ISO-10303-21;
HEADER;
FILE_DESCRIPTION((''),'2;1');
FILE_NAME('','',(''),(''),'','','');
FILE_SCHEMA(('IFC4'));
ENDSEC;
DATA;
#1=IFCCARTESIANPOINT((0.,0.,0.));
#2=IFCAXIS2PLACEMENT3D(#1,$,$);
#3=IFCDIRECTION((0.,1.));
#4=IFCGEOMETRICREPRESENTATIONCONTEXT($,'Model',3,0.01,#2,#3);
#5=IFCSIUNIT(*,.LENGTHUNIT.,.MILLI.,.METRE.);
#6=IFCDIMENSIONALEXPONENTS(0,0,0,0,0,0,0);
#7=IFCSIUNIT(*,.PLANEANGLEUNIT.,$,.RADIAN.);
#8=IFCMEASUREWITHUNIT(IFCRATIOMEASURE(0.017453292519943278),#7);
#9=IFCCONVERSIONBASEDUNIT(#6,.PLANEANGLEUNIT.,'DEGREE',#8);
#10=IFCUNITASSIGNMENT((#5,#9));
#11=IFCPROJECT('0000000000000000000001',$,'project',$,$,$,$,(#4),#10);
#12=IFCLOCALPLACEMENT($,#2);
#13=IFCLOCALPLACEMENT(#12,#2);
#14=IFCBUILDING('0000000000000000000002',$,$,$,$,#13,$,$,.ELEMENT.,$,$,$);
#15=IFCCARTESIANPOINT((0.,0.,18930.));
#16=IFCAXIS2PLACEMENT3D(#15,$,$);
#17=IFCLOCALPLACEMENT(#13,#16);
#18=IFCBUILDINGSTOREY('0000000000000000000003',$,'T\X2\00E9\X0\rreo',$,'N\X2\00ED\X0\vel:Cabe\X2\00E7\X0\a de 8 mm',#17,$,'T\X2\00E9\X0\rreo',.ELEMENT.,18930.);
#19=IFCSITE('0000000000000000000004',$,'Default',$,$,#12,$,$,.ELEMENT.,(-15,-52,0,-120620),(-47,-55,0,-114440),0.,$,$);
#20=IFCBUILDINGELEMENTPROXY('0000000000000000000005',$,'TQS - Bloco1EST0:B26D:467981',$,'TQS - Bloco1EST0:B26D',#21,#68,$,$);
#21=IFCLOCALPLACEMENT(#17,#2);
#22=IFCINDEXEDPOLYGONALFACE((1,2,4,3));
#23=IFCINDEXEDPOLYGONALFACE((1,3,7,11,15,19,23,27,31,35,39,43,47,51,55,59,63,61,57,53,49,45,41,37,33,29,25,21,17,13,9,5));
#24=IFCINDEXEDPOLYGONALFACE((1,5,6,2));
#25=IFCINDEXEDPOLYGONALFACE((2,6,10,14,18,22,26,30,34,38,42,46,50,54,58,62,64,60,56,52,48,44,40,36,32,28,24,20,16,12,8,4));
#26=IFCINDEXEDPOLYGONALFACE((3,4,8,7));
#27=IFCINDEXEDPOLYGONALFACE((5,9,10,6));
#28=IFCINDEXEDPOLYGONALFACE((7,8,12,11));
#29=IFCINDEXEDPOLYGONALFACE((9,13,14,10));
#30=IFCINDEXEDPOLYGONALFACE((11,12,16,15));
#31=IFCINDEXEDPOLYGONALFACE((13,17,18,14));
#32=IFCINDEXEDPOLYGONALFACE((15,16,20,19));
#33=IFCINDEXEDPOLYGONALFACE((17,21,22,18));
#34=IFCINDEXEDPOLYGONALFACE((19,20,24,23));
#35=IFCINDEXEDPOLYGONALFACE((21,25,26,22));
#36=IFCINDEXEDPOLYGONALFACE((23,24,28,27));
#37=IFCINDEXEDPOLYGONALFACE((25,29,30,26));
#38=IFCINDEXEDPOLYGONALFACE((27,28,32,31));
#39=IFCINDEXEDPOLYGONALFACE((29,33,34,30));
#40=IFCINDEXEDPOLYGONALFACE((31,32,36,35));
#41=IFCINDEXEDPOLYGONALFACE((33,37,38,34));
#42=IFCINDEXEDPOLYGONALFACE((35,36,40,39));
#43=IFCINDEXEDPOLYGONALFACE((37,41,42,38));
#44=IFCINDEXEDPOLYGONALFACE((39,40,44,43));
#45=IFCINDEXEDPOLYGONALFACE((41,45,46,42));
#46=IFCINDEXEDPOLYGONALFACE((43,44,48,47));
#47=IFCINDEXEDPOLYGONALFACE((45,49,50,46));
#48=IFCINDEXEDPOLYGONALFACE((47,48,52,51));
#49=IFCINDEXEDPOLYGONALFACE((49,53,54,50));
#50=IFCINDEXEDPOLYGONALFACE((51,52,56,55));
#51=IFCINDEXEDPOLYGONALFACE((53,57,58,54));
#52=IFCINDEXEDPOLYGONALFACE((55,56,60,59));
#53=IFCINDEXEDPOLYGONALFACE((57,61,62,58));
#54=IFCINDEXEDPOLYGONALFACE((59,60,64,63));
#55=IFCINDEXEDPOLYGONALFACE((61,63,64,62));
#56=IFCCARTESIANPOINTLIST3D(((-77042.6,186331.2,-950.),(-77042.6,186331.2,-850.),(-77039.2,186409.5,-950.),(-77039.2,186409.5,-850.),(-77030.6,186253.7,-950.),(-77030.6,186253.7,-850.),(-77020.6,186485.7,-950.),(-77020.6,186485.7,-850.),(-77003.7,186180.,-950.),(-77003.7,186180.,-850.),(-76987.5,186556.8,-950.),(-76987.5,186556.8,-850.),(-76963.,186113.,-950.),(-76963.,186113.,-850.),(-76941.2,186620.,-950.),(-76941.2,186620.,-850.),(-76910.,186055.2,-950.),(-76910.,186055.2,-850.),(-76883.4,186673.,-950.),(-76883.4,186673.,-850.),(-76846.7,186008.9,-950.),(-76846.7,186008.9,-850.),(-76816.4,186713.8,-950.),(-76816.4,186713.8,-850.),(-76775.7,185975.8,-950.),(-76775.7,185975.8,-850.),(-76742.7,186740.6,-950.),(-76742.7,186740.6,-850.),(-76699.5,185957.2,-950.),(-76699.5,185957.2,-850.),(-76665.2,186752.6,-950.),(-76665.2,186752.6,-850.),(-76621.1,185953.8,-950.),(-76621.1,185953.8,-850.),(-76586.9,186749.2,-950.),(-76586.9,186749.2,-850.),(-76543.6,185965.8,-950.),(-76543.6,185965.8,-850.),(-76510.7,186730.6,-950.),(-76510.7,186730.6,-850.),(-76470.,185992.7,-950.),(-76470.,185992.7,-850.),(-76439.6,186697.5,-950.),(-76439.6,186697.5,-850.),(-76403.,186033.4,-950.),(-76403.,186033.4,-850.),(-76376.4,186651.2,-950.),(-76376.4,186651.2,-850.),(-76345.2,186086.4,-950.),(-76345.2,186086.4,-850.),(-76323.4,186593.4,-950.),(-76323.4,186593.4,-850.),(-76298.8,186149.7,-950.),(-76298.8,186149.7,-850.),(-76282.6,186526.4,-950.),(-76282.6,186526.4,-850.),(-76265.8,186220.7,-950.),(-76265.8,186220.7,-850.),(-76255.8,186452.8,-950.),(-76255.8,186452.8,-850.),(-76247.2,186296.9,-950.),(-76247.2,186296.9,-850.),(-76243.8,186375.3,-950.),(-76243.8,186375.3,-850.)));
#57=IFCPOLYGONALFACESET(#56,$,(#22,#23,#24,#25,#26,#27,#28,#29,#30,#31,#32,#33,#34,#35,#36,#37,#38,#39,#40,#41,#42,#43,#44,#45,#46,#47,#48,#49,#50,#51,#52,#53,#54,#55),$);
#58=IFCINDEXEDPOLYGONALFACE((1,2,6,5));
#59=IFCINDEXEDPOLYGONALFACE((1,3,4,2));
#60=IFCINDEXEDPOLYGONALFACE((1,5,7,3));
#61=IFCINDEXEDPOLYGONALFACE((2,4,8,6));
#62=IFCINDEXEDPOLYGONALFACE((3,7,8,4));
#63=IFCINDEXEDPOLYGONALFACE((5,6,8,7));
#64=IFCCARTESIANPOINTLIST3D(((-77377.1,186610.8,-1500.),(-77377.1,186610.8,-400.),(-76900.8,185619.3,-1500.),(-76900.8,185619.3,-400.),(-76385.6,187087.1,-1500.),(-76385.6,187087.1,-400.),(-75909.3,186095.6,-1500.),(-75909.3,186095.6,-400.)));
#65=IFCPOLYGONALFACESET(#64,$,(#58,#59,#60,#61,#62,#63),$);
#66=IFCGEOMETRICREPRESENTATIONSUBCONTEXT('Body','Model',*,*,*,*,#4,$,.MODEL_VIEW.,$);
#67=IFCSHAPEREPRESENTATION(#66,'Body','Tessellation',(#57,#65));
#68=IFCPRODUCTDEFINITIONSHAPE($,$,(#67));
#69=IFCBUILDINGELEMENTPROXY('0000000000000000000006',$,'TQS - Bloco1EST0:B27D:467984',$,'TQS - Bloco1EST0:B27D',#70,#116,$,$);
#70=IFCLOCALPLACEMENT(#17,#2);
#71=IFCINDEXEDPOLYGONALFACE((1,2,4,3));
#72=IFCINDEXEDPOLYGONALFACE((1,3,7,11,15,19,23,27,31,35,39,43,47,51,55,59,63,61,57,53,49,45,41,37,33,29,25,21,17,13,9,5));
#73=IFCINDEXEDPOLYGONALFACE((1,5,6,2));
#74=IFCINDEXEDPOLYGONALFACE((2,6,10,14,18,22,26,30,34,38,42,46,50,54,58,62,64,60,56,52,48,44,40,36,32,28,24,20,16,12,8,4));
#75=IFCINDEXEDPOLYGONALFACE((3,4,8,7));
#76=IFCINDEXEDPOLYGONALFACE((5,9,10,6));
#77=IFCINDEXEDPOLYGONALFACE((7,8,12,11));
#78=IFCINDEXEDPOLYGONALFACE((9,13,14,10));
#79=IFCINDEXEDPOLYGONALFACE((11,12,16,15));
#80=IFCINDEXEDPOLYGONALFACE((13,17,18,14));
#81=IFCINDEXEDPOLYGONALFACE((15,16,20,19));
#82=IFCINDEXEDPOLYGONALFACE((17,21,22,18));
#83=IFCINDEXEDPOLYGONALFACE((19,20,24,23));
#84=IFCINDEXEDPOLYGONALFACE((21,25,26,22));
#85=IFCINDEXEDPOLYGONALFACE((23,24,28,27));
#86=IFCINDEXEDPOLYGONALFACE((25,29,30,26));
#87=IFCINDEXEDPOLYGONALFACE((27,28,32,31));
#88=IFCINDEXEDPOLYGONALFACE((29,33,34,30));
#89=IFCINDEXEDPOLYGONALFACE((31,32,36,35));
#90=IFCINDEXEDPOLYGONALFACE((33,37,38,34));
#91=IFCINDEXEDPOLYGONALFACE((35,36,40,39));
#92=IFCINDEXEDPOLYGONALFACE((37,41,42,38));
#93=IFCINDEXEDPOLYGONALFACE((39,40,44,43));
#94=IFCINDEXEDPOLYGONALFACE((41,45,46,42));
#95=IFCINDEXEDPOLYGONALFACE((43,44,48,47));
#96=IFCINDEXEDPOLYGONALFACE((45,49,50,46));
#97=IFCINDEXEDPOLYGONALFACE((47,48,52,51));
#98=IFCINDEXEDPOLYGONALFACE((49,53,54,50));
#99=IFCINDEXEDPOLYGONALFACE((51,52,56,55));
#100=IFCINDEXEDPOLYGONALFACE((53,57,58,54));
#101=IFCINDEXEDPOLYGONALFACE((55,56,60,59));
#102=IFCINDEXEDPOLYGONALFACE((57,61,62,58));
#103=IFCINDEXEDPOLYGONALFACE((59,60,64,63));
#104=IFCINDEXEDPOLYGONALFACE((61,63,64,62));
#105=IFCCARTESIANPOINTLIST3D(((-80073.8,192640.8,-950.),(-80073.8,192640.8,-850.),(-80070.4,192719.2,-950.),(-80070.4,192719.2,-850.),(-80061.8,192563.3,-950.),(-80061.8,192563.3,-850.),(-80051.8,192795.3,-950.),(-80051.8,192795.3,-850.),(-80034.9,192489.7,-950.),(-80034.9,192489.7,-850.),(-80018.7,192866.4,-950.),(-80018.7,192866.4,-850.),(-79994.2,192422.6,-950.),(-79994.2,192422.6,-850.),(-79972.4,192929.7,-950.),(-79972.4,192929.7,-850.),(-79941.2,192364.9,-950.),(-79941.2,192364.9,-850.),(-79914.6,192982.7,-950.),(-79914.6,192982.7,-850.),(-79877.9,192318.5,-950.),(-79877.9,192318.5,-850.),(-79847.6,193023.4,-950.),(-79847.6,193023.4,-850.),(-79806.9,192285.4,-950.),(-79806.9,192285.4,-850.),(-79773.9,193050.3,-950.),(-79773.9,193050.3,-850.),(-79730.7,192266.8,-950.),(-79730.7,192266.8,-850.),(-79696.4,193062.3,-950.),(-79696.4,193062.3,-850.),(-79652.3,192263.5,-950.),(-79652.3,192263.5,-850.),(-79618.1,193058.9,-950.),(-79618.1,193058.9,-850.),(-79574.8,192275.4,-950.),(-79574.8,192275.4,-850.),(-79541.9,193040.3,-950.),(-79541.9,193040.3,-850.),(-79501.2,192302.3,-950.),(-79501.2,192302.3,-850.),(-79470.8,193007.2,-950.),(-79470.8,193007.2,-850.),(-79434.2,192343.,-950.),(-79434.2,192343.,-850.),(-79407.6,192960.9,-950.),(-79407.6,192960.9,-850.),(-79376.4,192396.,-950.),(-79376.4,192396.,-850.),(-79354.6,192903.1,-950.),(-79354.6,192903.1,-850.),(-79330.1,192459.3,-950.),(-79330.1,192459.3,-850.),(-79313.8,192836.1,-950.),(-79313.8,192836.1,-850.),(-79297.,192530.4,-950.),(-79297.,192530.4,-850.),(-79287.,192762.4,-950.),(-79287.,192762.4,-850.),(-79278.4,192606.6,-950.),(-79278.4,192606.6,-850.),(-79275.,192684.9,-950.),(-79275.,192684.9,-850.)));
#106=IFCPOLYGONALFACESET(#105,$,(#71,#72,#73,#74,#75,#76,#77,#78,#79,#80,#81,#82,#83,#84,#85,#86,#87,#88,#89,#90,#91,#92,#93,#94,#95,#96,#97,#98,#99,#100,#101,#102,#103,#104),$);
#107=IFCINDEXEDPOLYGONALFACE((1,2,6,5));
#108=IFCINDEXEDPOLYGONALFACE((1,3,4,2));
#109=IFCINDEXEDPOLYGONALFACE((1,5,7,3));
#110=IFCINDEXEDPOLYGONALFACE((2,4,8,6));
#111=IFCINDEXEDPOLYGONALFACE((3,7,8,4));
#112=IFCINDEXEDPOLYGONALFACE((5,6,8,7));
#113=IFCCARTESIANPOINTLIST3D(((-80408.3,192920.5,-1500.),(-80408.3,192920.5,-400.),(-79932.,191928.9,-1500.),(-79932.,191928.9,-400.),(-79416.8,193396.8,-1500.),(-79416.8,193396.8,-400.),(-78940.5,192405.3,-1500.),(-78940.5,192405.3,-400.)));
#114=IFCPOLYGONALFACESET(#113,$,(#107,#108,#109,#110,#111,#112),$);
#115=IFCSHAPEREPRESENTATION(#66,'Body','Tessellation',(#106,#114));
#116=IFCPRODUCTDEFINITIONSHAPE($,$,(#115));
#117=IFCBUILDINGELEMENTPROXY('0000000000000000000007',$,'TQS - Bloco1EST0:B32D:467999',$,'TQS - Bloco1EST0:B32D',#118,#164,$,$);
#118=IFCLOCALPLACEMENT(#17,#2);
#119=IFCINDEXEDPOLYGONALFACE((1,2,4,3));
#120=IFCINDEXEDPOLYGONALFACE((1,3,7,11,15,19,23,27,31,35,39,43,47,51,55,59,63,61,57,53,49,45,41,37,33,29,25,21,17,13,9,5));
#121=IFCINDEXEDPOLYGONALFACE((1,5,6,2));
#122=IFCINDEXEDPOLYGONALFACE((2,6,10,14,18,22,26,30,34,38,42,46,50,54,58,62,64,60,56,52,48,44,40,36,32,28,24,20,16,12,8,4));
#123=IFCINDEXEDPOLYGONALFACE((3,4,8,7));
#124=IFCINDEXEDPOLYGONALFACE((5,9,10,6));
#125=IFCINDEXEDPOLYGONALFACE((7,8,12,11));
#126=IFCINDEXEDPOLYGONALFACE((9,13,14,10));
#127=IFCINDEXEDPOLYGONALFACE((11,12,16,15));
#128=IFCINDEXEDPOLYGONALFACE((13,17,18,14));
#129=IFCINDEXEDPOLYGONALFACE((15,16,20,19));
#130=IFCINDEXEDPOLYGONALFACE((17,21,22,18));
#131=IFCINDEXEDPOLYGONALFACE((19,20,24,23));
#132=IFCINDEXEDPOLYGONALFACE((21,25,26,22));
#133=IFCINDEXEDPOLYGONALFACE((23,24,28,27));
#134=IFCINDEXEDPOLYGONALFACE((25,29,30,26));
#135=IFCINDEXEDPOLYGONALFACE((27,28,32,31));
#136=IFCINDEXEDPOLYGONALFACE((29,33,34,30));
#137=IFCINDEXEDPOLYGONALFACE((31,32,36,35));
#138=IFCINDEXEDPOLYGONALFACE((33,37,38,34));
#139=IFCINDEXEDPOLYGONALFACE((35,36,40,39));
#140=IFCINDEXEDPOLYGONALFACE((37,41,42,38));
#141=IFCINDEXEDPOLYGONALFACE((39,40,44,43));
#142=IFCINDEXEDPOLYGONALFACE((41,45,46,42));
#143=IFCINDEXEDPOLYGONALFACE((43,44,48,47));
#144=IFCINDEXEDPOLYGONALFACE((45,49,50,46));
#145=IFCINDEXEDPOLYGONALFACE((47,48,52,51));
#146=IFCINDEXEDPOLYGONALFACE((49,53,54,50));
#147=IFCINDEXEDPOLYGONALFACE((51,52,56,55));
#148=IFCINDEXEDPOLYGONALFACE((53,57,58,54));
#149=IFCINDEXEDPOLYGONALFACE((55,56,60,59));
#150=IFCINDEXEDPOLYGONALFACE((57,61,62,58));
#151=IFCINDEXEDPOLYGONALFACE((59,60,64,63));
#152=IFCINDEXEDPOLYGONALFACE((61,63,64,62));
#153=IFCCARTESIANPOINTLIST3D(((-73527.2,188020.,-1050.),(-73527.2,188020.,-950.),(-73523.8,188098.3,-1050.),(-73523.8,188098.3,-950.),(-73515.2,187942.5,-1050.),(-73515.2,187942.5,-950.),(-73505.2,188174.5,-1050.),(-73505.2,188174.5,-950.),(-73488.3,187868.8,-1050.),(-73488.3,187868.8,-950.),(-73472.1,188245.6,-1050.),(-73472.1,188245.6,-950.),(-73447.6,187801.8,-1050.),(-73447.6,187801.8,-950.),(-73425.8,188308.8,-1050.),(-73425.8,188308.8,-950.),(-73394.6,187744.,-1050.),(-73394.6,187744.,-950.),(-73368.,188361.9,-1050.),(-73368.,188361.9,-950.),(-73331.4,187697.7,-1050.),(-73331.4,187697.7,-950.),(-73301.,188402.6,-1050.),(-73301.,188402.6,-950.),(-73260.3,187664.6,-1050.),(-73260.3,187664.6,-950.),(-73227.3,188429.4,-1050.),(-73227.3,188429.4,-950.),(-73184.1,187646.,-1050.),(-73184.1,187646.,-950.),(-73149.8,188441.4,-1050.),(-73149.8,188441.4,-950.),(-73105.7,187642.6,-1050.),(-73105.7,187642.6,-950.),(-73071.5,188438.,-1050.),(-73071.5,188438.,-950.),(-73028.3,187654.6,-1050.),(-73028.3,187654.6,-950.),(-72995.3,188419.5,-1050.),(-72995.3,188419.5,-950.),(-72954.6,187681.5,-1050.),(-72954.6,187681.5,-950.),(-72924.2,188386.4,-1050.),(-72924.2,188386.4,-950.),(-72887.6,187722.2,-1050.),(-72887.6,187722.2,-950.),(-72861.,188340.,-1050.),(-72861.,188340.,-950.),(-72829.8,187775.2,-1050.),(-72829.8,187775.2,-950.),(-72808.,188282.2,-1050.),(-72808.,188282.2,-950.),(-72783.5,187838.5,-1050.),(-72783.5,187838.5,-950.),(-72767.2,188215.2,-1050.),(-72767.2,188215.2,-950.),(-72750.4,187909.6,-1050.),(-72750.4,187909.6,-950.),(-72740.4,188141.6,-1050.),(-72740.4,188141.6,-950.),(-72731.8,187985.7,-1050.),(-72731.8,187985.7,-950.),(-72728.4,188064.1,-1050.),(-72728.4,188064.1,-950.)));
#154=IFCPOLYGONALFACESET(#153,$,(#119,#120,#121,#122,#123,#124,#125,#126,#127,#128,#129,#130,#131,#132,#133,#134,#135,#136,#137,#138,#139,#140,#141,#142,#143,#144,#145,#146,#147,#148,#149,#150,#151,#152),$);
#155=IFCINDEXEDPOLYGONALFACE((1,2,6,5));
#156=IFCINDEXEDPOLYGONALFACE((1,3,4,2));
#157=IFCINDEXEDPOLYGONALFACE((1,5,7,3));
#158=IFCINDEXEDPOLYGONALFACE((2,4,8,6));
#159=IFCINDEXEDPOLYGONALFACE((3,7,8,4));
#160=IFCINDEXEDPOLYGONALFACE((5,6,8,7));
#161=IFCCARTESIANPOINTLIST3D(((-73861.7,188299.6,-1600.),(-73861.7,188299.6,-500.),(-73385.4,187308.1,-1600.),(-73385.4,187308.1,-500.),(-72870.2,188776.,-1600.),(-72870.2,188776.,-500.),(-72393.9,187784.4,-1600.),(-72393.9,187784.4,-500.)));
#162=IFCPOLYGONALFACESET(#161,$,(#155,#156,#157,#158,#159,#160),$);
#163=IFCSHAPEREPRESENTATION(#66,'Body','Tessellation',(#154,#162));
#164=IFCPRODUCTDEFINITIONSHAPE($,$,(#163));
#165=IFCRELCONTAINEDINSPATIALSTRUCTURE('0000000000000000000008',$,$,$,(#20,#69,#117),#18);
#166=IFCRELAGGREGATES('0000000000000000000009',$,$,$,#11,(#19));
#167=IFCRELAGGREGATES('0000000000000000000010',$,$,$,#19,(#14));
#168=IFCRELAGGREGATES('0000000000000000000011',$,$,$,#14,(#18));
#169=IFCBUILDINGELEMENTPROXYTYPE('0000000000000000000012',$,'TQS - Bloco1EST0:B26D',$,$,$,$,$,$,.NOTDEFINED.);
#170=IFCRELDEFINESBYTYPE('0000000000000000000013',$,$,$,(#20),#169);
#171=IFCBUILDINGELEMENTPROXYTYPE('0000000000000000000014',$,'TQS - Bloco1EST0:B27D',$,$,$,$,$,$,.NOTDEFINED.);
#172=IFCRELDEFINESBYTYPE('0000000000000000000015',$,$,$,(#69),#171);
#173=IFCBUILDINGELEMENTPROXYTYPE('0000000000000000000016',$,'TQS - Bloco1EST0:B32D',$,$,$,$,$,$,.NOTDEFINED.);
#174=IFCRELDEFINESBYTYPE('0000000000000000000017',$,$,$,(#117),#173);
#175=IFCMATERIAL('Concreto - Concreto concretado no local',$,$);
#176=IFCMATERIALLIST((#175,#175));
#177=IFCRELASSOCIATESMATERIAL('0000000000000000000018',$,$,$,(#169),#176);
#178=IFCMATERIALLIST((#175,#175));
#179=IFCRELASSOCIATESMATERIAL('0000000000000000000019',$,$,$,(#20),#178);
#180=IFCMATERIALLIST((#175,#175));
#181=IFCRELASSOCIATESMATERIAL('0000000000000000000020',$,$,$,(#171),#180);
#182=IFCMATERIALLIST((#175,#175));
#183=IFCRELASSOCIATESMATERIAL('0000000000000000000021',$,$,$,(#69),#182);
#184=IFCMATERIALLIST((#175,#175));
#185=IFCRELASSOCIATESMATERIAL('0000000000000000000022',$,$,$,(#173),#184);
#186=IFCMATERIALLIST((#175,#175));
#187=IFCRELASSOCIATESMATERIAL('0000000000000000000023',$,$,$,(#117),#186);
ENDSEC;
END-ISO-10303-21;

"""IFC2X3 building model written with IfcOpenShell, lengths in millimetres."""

from ifc_helpers import new_model, entity, si_unit, converted_unit, direction, frame, frame_2d, origin, origin_2d_with_axis, place, context, subcontext, project, spatial, rectangle, circle, extrude, source, transform, mapped, material, material_list, type_object, type_shapes, element, save


model = new_model("IFC2X3")

# Units and contexts
model_context = context("Model", 3, precision=0.01, world=origin(), true_north=direction((0.0, 1.0)))
body_context = subcontext(model_context, "Body", "Model", "MODEL_VIEW")
ifc_project = project(units=[si_unit("LENGTHUNIT", "METRE", prefix="MILLI"), converted_unit("PLANEANGLEUNIT", "DEGREE", entity("IfcRatioMeasure", 0.017453292519943278), si_unit("PLANEANGLEUNIT", "RADIAN"), dimensions=[0, 0, 0, 0, 0, 0, 0])], contexts=[model_context])

# Site, building, storey
site_placement = place(None, origin())
site = spatial("IfcSite", under=ifc_project, at=site_placement, Name="Default", CompositionType="ELEMENT", RefLatitude=(-15, -52, 0, -120620), RefLongitude=(-47, -55, 0, -114440), RefElevation=0.0)
building_placement = place(site_placement, origin())
building = spatial("IfcBuilding", under=site, at=building_placement, CompositionType="ELEMENT")
storey_placement = place(building_placement, frame((0.0, 0.0, 18930.0)))
storey = spatial("IfcBuildingStorey", under=building, at=storey_placement, Name="Térreo", ObjectType="Nível:Cabeça de 8 mm", LongName="Térreo", CompositionType="ELEMENT", Elevation=18930.0)

# Building element proxies
ifc_material_1 = material(Name="Concreto - Concreto concretado no local")
ifc_material_list_1 = material_list([ifc_material_1, ifc_material_1])
ifc_material_list_2 = material_list([ifc_material_1, ifc_material_1])
building_element_proxy_type_1 = type_object("IfcBuildingElementProxyType", Name="TQS - Bloco1EST0:B26D", PredefinedType="NOTDEFINED", material=ifc_material_list_2)
shared_shape_1 = source(origin(), body_context, "Body", "SweptSolid", [
    extrude(circle(Radius=400.0, at=frame_2d((0.0, 0.0), x_axis=(1.0, 0.0))), frame((0.0, 0.0, -550.0)), (0.0, 0.0, 1.0), 100.0),
    extrude(rectangle(XDim=1100.0, YDim=1100.0, at=origin_2d_with_axis()), frame((0.0, 0.0, -1100.0), z_axis=(0.0, 0.0, 1.0), x_axis=(-1.0, 0.0, 0.0)), (0.0, 0.0, 1.0), 1100.0),
])
type_shapes(building_element_proxy_type_1, [shared_shape_1])
proxy_1_placement = place(storey_placement, frame((-76643.2, 186353.2, -400.0), z_axis=(0.0, 0.0, 1.0), x_axis=(-0.43303, 0.90138, 0.0)))
element("IfcBuildingElementProxy", 1, at=proxy_1_placement, inside=storey, type_object=building_element_proxy_type_1, material=ifc_material_list_1, Name="TQS - Bloco1EST0:B26D:467981", ObjectType="TQS - Bloco1EST0:B26D", context=body_context, shape_type="MappedRepresentation", body=[
    mapped(shared_shape_1, transform((0.0, 0.0, 0.0), scale=1.0)),
])
ifc_material_list_3 = material_list([ifc_material_1, ifc_material_1])
ifc_material_list_4 = material_list([ifc_material_1, ifc_material_1])
building_element_proxy_type_2 = type_object("IfcBuildingElementProxyType", Name="TQS - Bloco1EST0:B27D", PredefinedType="NOTDEFINED", material=ifc_material_list_4)
shared_shape_2 = source(origin(), body_context, "Body", "SweptSolid", [
    extrude(circle(Radius=400.0, at=frame_2d((0.0, 0.0), x_axis=(1.0, 0.0))), frame((0.0, 0.0, -550.0)), (0.0, 0.0, 1.0), 100.0),
    extrude(rectangle(XDim=1100.0, YDim=1100.0, at=origin_2d_with_axis()), frame((0.0, 0.0, -1100.0), z_axis=(0.0, 0.0, 1.0), x_axis=(-1.0, 0.0, 0.0)), (0.0, 0.0, 1.0), 1100.0),
])
type_shapes(building_element_proxy_type_2, [shared_shape_2])
proxy_2_placement = place(storey_placement, frame((-79674.4, 192662.9, -400.0), z_axis=(0.0, 0.0, 1.0), x_axis=(-0.43303, 0.90138, 0.0)))
element("IfcBuildingElementProxy", 2, at=proxy_2_placement, inside=storey, type_object=building_element_proxy_type_2, material=ifc_material_list_3, Name="TQS - Bloco1EST0:B27D:467984", ObjectType="TQS - Bloco1EST0:B27D", context=body_context, shape_type="MappedRepresentation", body=[
    mapped(shared_shape_2, transform((0.0, 0.0, 0.0), scale=1.0)),
])
ifc_material_list_5 = material_list([ifc_material_1, ifc_material_1])
ifc_material_list_6 = material_list([ifc_material_1, ifc_material_1])
building_element_proxy_type_3 = type_object("IfcBuildingElementProxyType", Name="TQS - Bloco1EST0:B32D", PredefinedType="NOTDEFINED", material=ifc_material_list_6)
shared_shape_3 = source(origin(), body_context, "Body", "SweptSolid", [
    extrude(circle(Radius=400.0, at=frame_2d((0.0, 0.0), x_axis=(1.0, 0.0))), frame((0.0, 0.0, -550.0)), (0.0, 0.0, 1.0), 100.0),
    extrude(rectangle(XDim=1100.0, YDim=1100.0, at=origin_2d_with_axis()), frame((0.0, 0.0, -1100.0), z_axis=(0.0, 0.0, 1.0), x_axis=(-1.0, 0.0, 0.0)), (0.0, 0.0, 1.0), 1100.0),
])
type_shapes(building_element_proxy_type_3, [shared_shape_3])
proxy_3_placement = place(storey_placement, frame((-73127.8, 188042.0, -500.0), z_axis=(0.0, 0.0, 1.0), x_axis=(-0.43303, 0.90138, 0.0)))
element("IfcBuildingElementProxy", 3, at=proxy_3_placement, inside=storey, type_object=building_element_proxy_type_3, material=ifc_material_list_5, Name="TQS - Bloco1EST0:B32D:467999", ObjectType="TQS - Bloco1EST0:B32D", context=body_context, shape_type="MappedRepresentation", body=[
    mapped(shared_shape_3, transform((0.0, 0.0, 0.0), scale=1.0)),
])

save(model, "model.ifc")
